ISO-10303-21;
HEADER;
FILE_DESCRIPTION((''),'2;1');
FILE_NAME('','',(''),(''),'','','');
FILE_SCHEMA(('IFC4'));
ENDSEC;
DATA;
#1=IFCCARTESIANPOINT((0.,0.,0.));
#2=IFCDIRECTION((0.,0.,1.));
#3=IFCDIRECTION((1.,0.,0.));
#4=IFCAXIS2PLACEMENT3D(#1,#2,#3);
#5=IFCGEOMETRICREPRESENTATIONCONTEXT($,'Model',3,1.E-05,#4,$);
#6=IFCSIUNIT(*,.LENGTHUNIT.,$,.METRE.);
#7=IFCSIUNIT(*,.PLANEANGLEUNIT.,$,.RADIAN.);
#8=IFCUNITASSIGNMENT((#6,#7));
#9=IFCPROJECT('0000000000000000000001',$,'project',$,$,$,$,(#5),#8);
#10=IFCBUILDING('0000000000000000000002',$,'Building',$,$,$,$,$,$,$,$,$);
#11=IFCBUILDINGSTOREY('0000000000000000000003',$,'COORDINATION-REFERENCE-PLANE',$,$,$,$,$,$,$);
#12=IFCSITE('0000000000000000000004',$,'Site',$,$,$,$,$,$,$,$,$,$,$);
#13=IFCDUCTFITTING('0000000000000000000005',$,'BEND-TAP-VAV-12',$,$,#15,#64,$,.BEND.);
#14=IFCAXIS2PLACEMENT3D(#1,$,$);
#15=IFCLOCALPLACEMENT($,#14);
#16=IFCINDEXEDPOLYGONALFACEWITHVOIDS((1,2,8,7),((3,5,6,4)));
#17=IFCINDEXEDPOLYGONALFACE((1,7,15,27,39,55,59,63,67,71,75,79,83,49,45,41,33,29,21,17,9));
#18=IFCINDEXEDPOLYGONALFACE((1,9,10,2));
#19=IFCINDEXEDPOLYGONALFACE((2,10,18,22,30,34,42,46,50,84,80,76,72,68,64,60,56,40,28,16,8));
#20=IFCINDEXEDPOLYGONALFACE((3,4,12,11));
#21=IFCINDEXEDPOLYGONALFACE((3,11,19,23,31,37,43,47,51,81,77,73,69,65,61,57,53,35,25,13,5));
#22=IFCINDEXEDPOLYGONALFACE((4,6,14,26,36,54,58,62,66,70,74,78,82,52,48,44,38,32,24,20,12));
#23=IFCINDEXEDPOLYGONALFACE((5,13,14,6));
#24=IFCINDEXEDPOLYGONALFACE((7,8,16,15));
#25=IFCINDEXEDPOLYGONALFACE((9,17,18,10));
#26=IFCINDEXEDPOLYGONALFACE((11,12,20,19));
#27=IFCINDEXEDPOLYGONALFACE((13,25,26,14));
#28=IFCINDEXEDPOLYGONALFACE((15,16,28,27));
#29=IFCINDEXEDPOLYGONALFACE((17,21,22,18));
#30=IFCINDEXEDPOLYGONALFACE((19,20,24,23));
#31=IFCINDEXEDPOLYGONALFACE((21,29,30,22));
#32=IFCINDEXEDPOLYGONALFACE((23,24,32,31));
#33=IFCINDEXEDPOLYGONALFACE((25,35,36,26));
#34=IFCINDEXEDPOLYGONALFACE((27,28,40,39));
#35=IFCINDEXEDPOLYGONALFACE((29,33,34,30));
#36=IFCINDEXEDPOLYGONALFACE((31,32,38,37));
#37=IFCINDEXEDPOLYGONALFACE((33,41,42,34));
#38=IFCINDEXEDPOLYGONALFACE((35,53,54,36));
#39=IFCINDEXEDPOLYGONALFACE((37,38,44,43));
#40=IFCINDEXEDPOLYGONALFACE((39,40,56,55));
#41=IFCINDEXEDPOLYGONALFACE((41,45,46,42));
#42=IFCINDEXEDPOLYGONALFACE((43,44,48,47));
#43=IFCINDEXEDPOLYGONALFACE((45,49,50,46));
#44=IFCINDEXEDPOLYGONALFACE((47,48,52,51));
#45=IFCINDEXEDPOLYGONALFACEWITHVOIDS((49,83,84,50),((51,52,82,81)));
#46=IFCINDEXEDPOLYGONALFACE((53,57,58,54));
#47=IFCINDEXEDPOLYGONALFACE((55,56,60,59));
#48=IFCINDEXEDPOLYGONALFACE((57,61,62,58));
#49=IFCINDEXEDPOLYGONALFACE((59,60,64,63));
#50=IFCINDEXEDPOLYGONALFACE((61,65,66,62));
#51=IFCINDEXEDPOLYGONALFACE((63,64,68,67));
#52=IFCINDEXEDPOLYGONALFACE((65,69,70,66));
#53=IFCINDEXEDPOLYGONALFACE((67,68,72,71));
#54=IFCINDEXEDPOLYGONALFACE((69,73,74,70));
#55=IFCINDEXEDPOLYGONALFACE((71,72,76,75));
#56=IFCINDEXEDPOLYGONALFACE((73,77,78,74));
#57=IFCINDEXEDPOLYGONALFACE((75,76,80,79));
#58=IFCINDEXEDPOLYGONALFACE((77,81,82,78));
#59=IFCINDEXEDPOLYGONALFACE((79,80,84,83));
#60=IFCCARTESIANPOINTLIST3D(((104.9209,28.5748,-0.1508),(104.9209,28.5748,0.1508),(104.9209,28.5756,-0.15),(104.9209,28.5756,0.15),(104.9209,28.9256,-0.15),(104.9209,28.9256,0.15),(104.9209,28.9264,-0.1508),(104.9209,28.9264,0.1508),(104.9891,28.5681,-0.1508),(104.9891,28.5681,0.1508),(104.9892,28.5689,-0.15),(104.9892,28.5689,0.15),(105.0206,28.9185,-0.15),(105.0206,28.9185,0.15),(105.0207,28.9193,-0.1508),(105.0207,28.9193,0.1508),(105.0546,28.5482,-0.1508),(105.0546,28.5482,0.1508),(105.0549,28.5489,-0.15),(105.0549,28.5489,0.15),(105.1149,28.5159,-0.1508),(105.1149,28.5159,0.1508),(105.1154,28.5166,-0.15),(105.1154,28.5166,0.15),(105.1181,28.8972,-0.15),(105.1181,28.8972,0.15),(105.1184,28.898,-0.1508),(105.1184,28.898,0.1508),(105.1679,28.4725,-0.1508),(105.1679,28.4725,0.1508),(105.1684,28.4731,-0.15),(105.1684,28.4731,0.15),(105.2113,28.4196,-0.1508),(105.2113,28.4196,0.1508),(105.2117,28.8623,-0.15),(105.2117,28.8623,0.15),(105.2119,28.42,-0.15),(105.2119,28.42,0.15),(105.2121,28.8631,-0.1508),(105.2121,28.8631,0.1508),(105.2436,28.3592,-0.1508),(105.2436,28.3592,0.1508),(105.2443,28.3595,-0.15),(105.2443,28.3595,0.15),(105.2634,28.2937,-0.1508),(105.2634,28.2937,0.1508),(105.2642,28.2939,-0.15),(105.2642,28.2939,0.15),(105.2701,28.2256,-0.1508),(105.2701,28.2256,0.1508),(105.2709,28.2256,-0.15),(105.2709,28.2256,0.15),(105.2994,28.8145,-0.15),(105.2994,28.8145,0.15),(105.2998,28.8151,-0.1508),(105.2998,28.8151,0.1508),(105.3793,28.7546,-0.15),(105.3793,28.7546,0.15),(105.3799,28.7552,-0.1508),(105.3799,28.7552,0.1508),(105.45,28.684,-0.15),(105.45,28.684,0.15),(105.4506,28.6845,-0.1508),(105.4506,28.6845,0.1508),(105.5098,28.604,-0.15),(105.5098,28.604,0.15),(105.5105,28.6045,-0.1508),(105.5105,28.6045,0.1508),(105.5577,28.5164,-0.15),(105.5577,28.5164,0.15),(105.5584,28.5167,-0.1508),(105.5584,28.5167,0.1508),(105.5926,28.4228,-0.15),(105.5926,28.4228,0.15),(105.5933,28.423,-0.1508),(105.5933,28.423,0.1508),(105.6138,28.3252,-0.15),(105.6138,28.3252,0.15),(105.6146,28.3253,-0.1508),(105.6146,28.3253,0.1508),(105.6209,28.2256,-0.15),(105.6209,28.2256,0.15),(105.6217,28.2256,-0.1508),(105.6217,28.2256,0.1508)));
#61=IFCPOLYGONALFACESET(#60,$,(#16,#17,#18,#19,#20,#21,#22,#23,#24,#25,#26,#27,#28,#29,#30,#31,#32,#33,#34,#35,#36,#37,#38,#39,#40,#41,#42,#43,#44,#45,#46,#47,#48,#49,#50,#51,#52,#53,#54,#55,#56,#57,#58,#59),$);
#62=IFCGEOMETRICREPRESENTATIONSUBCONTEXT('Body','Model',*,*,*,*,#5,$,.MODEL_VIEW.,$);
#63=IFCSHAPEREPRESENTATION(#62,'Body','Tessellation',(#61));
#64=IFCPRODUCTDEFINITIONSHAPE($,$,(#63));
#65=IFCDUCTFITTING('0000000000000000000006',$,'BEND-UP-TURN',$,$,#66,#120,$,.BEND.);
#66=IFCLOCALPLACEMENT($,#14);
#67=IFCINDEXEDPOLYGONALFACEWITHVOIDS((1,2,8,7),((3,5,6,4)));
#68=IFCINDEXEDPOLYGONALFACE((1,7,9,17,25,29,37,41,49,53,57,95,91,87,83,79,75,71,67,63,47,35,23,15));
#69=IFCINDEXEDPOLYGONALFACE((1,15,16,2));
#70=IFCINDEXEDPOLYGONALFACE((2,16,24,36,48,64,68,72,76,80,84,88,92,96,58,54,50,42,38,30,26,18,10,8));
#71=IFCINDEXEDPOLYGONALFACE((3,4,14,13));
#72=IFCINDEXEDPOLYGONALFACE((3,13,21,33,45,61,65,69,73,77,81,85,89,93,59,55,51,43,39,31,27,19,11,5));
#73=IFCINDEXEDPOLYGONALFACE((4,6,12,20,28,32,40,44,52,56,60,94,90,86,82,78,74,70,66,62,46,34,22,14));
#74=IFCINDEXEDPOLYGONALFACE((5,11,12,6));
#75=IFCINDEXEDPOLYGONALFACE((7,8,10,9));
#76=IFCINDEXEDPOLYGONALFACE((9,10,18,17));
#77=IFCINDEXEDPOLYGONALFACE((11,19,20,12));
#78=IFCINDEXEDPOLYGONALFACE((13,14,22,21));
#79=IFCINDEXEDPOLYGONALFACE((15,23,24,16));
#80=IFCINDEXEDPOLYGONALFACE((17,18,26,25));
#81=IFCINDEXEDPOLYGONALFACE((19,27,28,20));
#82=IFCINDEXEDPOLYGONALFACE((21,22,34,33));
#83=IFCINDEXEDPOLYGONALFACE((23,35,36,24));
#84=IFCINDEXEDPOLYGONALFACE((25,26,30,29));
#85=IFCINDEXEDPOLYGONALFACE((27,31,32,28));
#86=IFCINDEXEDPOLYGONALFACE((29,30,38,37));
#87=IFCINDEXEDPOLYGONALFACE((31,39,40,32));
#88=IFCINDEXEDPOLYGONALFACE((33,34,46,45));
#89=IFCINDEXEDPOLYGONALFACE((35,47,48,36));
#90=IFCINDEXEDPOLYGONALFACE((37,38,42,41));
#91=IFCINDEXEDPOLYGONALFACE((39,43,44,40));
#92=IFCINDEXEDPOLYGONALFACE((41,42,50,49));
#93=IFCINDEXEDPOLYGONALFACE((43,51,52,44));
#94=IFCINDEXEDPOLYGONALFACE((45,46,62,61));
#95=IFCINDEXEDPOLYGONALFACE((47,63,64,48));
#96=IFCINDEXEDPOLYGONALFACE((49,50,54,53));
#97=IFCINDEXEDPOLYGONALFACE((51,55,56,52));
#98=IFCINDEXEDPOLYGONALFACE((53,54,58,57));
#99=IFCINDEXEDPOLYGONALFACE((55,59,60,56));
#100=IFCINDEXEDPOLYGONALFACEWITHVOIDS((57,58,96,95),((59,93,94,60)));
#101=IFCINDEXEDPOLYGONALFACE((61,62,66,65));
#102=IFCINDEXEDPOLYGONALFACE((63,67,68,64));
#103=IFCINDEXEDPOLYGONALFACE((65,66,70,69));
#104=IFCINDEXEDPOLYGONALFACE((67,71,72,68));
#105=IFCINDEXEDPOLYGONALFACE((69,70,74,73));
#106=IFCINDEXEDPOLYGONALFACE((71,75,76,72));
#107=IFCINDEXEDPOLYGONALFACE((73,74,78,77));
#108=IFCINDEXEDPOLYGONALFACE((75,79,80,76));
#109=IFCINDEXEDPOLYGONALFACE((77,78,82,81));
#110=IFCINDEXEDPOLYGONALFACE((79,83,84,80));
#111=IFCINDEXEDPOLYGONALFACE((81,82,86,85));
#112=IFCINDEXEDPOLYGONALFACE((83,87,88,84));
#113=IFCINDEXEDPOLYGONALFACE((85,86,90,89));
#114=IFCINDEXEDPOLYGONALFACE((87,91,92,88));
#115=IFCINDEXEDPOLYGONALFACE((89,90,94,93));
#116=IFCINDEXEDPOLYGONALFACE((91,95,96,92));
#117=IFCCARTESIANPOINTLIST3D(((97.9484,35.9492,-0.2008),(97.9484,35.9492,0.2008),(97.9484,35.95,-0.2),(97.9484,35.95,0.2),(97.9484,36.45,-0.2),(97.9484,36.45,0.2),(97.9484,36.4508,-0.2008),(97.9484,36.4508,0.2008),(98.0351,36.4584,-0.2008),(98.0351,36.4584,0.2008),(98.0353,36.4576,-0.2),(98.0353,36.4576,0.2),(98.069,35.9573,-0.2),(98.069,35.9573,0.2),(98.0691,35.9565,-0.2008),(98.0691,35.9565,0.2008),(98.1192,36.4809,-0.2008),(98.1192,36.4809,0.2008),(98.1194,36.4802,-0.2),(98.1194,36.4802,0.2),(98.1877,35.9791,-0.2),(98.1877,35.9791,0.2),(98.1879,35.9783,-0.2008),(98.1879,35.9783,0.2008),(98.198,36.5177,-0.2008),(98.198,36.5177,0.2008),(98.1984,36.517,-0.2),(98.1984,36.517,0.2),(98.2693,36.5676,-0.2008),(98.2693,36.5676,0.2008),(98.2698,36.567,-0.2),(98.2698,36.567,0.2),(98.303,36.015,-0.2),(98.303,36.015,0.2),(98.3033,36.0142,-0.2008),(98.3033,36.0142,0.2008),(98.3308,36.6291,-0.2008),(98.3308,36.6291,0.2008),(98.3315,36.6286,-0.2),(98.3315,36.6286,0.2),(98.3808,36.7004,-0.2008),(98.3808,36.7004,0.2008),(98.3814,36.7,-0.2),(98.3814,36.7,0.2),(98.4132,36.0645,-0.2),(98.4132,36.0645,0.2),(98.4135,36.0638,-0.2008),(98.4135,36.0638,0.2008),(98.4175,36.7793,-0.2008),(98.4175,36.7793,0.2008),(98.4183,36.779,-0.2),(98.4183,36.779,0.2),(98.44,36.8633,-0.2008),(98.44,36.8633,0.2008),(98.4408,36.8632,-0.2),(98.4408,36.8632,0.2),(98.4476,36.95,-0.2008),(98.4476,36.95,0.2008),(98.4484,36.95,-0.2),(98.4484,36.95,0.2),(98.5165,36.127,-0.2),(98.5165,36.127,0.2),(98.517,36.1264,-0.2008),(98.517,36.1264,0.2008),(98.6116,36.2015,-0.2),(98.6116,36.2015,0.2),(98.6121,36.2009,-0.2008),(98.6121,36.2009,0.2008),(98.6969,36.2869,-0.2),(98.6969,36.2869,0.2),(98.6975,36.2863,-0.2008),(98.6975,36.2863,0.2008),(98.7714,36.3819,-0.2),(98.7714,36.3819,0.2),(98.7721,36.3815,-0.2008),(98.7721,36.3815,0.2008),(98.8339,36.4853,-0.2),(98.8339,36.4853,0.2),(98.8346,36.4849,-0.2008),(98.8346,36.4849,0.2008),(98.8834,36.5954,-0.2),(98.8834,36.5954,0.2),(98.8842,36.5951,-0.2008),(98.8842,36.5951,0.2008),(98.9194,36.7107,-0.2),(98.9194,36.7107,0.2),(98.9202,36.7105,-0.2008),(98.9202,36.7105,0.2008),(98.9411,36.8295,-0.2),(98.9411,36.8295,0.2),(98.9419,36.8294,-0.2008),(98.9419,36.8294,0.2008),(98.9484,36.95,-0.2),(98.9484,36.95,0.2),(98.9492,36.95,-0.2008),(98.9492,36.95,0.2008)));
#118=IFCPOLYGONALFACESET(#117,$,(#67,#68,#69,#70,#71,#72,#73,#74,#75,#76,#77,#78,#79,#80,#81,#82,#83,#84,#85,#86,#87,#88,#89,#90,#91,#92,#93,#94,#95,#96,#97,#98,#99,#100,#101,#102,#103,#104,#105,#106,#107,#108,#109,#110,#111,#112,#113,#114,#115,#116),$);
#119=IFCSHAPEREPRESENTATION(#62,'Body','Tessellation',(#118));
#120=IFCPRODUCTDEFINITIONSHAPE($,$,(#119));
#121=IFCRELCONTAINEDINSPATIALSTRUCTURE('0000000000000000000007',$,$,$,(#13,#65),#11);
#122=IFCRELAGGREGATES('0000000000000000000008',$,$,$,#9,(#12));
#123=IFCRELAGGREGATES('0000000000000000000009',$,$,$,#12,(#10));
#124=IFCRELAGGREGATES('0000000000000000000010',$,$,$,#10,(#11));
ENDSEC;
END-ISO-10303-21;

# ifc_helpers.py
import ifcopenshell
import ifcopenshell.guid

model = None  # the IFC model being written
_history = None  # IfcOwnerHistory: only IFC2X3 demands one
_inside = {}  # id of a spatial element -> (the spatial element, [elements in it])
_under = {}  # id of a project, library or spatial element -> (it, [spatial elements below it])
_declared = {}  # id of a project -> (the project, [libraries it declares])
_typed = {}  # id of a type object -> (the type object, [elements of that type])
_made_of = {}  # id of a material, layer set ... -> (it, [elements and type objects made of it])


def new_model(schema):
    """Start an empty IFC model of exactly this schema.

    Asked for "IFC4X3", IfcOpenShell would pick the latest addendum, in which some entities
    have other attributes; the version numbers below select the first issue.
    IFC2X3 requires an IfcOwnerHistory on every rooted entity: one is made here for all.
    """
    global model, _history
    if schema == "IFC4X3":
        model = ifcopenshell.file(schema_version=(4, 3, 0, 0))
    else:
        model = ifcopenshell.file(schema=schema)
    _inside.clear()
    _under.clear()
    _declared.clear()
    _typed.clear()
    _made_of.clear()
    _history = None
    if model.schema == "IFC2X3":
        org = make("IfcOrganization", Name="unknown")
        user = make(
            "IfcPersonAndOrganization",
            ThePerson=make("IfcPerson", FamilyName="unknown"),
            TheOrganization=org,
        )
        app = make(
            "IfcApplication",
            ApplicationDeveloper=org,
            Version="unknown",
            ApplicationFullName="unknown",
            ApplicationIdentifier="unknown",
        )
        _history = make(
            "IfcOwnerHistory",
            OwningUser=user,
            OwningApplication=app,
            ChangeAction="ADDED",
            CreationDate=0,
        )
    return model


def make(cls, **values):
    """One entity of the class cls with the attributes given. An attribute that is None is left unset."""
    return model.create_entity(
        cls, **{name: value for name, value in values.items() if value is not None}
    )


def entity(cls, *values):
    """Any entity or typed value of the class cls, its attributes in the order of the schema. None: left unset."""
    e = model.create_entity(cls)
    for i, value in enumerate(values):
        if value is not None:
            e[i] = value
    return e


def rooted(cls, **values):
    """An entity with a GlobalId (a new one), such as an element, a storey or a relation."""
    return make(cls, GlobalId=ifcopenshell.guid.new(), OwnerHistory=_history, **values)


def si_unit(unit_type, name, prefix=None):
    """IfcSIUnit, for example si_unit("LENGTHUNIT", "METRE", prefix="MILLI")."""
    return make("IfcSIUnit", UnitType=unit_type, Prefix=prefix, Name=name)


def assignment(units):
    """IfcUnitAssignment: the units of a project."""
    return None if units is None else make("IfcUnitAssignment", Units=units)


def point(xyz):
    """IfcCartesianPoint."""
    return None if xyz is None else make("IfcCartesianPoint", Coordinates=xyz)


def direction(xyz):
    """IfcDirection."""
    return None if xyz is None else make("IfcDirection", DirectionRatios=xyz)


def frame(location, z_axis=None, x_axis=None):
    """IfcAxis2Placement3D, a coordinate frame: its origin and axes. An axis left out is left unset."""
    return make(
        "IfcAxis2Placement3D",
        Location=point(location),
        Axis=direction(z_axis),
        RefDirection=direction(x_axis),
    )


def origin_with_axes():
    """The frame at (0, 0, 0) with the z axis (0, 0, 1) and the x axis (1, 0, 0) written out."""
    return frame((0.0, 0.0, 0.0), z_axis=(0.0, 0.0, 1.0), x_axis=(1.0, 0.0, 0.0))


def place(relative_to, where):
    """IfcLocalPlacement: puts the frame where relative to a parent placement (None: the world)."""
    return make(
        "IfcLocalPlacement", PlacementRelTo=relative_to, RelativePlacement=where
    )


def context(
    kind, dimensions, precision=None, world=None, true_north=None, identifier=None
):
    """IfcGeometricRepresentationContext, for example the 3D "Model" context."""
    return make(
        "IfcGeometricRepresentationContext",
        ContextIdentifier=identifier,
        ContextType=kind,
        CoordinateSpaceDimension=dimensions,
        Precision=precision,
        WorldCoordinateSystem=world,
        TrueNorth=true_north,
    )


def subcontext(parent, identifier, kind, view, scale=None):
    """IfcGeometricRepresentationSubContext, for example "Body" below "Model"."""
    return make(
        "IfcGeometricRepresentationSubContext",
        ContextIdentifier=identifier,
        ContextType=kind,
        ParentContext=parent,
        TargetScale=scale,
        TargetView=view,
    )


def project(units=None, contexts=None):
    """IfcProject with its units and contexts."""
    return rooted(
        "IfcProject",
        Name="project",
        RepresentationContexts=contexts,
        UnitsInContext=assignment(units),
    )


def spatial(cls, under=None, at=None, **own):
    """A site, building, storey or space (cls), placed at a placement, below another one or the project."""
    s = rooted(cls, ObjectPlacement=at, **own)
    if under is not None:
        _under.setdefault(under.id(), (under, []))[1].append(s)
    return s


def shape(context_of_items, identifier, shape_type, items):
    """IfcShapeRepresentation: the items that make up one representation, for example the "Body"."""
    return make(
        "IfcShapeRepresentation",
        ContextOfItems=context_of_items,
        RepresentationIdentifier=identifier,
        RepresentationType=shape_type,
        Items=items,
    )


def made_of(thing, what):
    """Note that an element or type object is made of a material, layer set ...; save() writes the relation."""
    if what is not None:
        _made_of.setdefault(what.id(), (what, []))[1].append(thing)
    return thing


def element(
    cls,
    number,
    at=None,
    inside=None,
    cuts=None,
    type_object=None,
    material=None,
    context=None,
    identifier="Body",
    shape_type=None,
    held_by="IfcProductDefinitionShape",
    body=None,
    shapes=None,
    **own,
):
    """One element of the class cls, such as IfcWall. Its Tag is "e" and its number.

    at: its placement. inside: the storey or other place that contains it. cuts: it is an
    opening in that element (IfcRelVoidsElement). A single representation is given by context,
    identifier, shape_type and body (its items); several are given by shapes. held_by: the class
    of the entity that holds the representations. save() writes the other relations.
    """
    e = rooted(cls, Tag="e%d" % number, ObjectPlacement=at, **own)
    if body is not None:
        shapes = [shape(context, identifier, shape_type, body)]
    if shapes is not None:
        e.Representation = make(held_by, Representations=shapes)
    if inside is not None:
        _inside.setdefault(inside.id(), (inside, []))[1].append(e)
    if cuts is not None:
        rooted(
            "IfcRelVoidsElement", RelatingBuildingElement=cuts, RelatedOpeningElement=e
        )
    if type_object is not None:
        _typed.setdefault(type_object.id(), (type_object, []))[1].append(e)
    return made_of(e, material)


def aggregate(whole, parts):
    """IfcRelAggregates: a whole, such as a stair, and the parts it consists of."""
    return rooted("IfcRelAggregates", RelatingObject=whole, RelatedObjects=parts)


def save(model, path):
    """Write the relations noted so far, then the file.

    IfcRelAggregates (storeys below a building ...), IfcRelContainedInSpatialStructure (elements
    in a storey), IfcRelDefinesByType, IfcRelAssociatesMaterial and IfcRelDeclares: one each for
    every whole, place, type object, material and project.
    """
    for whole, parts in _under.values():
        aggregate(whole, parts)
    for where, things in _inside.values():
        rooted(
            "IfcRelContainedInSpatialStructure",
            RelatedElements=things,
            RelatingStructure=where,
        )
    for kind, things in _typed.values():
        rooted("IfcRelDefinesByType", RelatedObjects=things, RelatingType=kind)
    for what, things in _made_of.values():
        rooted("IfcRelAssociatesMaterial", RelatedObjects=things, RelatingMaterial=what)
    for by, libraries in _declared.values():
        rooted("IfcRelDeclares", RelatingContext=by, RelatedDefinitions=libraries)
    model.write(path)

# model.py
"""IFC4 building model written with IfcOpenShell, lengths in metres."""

from ifc_helpers import new_model, entity, si_unit, frame, origin_with_axes, place, context, subcontext, project, spatial, element, save


model = new_model("IFC4")

# Units and contexts
model_context = context("Model", 3, precision=1e-05, world=origin_with_axes())
body_context = subcontext(model_context, "Body", "Model", "MODEL_VIEW")
ifc_project = project(units=[si_unit("LENGTHUNIT", "METRE"), si_unit("PLANEANGLEUNIT", "RADIAN")], contexts=[model_context])

# Site, building, storey
site = spatial("IfcSite", under=ifc_project, Name="Site")
building = spatial("IfcBuilding", under=site, Name="Building")
storey = spatial("IfcBuildingStorey", under=building, Name="COORDINATION-REFERENCE-PLANE")

# Duct fittings
duct_fitting_1_placement = place(None, frame((104.9209, 28.2256, 0.0), z_axis=(0.0, 0.0, -1.0), x_axis=(0.0, 1.0, 0.0)))
cartesian_point_1 = entity("IfcCartesianPoint", [0.0, 0.0, 0.0])
element("IfcDuctFitting", 1, at=duct_fitting_1_placement, inside=storey, Name="BEND-TAP-VAV-12", PredefinedType="BEND", context=body_context, shape_type="SweptSolid", body=[
    entity("IfcRevolvedAreaSolid", entity("IfcRectangleHollowProfileDef", "AREA", None, entity("IfcAxis2Placement2D", entity("IfcCartesianPoint", [0.525, 0.0])), 0.3516, 0.3016, 0.0008), entity("IfcAxis2Placement3D", cartesian_point_1, entity("IfcDirection", [0.0, -1.0, 0.0]), entity("IfcDirection", [1.0, 0.0, 0.0])), entity("IfcAxis1Placement", cartesian_point_1, entity("IfcDirection", [0.0, 1.0, 0.0])), 1.570796),
])
duct_fitting_2_placement = place(None, frame((97.9484, 36.95, 0.0), z_axis=(0.0, 0.0, 1.0), x_axis=(0.0, -1.0, 0.0)))
cartesian_point_2 = entity("IfcCartesianPoint", [0.0, 0.0, 0.0])
element("IfcDuctFitting", 2, at=duct_fitting_2_placement, inside=storey, Name="BEND-UP-TURN", PredefinedType="BEND", context=body_context, shape_type="SweptSolid", body=[
    entity("IfcRevolvedAreaSolid", entity("IfcRectangleHollowProfileDef", "AREA", None, entity("IfcAxis2Placement2D", entity("IfcCartesianPoint", [0.75, 0.0])), 0.5016, 0.4016, 0.0008), entity("IfcAxis2Placement3D", cartesian_point_2, entity("IfcDirection", [0.0, -1.0, 0.0]), entity("IfcDirection", [1.0, 0.0, 0.0])), entity("IfcAxis1Placement", cartesian_point_2, entity("IfcDirection", [0.0, 1.0, 0.0])), 1.570796),
])

save(model, "model.ifc")
